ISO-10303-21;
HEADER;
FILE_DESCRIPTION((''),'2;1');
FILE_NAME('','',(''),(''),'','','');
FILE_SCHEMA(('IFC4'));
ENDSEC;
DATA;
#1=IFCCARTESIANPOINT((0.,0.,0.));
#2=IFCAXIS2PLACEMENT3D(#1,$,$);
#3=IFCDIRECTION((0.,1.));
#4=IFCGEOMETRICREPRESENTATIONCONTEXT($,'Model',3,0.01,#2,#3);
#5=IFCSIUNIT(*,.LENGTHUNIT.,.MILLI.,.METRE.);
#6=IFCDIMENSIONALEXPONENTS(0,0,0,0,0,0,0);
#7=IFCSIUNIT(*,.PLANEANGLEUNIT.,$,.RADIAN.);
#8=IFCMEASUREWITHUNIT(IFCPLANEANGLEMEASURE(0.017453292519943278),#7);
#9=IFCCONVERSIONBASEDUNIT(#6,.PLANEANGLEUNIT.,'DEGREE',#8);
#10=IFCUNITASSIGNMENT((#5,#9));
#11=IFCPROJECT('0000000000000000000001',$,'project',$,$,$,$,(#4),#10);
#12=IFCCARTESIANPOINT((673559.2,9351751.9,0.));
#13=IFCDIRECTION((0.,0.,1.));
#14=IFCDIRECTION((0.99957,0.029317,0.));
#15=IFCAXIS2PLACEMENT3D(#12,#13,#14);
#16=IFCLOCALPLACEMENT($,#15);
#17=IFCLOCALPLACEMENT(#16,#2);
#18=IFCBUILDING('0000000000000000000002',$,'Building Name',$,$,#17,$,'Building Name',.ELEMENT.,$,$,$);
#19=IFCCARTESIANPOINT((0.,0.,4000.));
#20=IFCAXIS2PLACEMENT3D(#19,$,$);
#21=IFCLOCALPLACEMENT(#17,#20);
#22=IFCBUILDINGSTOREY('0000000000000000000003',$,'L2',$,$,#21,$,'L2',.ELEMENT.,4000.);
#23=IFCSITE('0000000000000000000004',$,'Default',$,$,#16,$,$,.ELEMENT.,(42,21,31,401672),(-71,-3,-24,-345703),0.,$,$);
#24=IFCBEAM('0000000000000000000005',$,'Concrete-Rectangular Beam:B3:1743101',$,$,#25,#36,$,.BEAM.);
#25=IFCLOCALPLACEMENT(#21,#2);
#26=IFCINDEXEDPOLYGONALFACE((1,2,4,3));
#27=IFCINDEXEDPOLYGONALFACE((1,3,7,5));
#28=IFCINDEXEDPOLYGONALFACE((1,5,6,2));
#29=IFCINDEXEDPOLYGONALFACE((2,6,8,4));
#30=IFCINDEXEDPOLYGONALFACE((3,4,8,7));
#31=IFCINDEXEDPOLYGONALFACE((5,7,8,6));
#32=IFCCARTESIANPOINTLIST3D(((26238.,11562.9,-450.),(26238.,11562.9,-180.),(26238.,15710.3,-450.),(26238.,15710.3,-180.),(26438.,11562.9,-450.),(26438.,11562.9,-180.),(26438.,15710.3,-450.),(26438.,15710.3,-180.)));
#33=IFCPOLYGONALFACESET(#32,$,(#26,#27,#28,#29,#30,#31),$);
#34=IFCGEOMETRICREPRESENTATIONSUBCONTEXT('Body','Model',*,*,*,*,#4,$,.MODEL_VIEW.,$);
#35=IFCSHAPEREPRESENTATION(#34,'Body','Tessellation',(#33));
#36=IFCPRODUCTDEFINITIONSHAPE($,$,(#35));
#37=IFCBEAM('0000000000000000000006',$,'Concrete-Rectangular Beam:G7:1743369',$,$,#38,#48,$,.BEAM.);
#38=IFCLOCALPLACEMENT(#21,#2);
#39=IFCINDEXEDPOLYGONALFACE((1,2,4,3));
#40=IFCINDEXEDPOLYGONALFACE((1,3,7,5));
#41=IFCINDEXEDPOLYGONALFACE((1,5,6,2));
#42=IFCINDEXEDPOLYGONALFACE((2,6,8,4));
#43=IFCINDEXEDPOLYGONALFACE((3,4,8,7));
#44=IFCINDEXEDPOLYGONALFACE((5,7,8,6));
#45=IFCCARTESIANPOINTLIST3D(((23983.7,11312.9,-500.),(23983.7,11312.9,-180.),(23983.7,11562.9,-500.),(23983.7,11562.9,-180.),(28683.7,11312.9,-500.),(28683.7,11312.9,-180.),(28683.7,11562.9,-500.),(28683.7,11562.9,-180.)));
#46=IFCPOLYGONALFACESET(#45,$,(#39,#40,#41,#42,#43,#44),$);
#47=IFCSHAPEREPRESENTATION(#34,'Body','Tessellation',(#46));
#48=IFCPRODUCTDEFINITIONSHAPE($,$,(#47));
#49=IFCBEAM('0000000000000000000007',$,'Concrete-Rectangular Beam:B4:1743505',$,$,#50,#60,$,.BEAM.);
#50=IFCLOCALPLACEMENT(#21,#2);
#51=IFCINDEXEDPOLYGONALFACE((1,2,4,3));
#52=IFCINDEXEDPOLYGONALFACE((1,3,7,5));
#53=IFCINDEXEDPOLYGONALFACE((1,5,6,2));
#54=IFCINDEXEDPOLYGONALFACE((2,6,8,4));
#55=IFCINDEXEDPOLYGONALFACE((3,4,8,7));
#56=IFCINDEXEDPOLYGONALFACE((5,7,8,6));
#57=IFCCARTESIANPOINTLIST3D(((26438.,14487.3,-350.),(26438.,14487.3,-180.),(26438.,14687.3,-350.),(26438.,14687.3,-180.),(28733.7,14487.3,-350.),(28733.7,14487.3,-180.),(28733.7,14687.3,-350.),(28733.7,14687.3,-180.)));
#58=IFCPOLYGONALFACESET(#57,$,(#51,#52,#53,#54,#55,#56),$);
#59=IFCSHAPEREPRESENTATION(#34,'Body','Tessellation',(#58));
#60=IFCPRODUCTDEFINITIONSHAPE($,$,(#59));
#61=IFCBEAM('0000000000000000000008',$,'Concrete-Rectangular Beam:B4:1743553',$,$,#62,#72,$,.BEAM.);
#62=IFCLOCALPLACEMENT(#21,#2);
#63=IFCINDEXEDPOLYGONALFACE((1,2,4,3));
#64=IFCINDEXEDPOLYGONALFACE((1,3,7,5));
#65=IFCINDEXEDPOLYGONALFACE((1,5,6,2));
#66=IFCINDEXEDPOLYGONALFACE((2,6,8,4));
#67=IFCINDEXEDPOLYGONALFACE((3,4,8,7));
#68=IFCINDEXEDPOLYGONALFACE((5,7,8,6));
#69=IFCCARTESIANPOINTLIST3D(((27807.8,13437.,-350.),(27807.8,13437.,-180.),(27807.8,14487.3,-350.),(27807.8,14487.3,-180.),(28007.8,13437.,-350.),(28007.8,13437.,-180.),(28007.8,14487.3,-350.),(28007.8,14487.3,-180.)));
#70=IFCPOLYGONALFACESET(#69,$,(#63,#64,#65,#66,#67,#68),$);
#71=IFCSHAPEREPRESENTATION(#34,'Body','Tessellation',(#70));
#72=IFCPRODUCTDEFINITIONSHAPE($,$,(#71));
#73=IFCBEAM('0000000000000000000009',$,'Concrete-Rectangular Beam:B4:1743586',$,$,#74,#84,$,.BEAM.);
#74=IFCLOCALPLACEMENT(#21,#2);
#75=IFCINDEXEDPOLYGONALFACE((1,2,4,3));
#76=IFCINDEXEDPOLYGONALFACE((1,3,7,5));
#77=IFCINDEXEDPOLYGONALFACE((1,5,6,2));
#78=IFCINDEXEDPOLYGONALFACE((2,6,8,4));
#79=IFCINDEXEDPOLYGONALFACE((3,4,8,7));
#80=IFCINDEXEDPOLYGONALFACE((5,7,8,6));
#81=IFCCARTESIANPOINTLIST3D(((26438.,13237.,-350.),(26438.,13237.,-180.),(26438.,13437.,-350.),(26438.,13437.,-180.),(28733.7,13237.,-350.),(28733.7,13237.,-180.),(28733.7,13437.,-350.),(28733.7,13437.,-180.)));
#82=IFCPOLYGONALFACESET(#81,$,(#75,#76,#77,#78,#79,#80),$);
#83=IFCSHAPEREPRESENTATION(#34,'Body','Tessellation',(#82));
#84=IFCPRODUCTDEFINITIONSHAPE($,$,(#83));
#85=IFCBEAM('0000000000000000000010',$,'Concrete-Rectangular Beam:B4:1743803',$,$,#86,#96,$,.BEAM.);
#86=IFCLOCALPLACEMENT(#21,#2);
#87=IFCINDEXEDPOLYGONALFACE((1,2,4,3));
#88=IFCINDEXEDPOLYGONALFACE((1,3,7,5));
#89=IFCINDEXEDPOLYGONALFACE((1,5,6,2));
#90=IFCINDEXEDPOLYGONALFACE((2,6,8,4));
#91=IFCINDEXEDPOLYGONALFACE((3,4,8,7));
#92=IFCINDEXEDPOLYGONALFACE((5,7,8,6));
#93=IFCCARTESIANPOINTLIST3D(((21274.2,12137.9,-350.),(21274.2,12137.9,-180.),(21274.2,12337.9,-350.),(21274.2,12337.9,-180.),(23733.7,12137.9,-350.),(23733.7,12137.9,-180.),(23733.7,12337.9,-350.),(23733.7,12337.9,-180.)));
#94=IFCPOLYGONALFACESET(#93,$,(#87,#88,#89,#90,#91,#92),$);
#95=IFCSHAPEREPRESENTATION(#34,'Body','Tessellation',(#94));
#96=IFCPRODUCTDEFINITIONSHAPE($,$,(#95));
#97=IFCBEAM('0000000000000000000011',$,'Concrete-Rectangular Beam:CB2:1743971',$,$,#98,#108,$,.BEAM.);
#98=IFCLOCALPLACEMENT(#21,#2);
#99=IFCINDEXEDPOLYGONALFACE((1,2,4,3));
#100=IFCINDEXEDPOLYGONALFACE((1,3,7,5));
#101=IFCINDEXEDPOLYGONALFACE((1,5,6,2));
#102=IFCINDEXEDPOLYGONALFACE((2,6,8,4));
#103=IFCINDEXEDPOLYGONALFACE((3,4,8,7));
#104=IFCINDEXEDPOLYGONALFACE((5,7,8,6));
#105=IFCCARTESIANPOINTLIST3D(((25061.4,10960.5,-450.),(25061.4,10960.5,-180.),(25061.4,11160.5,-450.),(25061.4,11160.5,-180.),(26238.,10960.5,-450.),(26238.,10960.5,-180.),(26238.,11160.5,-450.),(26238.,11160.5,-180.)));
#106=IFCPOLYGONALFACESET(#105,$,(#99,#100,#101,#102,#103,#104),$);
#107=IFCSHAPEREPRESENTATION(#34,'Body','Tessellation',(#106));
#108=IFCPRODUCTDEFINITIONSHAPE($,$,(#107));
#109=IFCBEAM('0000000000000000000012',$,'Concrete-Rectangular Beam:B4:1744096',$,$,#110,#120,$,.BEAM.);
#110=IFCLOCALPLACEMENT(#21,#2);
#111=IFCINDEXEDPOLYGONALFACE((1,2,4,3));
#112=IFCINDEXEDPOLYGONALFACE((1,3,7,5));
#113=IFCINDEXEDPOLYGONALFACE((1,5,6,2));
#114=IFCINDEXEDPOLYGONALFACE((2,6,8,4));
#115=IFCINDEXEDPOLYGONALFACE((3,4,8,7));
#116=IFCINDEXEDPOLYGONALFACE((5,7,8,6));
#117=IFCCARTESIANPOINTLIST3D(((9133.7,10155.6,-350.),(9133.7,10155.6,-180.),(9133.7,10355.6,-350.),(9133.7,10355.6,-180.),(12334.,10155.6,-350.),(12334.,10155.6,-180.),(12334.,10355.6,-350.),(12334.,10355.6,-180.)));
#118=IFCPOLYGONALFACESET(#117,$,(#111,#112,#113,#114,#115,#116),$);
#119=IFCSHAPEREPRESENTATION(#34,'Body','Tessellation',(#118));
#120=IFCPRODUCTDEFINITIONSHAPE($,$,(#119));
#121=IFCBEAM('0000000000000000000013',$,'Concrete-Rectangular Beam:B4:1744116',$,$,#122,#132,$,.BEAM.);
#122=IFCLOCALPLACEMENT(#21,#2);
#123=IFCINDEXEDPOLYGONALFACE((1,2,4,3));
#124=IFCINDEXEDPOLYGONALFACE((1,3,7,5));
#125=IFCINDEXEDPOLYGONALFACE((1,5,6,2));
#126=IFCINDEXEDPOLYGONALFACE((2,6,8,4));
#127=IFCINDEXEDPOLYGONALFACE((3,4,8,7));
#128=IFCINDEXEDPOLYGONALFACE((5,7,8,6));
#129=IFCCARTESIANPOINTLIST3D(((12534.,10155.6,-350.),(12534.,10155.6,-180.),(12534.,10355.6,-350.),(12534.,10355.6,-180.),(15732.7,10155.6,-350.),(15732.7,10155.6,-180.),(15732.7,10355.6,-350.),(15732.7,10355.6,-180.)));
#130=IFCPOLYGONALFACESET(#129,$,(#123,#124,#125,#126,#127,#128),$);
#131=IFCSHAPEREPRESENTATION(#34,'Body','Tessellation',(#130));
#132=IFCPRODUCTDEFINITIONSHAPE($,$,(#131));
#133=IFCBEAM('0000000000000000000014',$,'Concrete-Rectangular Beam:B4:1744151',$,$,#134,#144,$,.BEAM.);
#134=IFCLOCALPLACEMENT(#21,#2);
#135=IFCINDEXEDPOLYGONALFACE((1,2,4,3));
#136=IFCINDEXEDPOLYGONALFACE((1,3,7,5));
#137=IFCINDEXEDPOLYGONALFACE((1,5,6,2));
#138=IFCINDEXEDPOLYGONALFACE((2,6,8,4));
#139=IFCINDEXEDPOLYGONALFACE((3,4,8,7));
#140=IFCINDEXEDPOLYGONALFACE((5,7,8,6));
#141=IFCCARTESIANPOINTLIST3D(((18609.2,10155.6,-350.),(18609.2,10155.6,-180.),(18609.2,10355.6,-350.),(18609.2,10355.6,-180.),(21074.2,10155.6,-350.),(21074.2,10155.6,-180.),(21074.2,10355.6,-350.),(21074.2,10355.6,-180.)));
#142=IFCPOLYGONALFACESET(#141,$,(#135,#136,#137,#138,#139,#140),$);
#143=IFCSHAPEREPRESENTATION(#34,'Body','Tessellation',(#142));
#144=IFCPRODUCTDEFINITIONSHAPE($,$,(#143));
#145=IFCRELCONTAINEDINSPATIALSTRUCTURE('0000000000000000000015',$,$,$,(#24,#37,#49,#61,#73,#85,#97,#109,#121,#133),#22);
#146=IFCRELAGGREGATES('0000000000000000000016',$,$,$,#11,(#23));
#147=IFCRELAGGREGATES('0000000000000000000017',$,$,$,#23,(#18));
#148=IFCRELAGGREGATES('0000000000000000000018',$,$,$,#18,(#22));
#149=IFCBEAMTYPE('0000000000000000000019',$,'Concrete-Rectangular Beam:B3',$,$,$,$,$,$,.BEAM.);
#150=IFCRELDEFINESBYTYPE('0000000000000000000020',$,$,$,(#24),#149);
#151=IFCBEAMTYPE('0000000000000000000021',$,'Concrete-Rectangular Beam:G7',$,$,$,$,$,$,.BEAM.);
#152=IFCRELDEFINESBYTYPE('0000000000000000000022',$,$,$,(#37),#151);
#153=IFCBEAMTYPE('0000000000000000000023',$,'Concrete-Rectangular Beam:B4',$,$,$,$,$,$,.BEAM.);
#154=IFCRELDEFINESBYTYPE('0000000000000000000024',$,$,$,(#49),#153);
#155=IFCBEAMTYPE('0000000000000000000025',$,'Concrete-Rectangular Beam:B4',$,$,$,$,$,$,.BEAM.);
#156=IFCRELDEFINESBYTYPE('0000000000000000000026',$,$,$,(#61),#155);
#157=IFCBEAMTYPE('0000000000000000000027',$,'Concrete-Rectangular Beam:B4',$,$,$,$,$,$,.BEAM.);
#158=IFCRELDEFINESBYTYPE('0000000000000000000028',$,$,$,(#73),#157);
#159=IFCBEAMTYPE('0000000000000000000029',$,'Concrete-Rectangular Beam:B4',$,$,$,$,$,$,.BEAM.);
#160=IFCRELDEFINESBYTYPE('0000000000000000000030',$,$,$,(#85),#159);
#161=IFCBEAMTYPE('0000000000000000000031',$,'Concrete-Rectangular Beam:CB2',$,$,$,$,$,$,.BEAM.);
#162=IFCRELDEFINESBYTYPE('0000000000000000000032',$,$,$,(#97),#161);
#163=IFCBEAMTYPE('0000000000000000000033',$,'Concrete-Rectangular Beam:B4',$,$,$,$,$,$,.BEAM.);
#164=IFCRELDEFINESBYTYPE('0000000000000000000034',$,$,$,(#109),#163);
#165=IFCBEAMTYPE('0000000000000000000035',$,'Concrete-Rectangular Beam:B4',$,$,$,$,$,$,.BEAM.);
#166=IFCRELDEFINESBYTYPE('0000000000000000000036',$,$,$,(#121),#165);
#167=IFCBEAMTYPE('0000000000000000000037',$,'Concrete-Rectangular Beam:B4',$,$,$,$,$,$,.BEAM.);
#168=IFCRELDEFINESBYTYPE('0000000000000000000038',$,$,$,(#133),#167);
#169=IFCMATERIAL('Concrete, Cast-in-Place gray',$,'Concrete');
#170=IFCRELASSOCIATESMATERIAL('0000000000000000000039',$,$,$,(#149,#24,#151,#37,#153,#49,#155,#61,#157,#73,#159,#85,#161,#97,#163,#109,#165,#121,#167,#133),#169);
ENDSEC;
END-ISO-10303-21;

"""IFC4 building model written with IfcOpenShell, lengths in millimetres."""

from ifc_helpers import new_model, entity, si_unit, converted_unit, direction, frame, origin, place, context, subcontext, project, spatial, indexed_curve, outline, extrude, source, transform, mapped, material, type_object, type_shapes, element, save


model = new_model("IFC4")

# Units and contexts
model_context = context("Model", 3, precision=0.01, world=origin(), true_north=direction((0.0, 1.0)))
body_context = subcontext(model_context, "Body", "Model", "MODEL_VIEW")
ifc_project = project(units=[si_unit("LENGTHUNIT", "METRE", prefix="MILLI"), converted_unit("PLANEANGLEUNIT", "DEGREE", entity("IfcPlaneAngleMeasure", 0.017453292519943278), si_unit("PLANEANGLEUNIT", "RADIAN"), dimensions=[0, 0, 0, 0, 0, 0, 0])], contexts=[model_context])

# Site, building, storey
site_placement = place(None, frame((673559.2, 9351751.9, 0.0), z_axis=(0.0, 0.0, 1.0), x_axis=(0.99957, 0.029317, 0.0)))
site = spatial("IfcSite", under=ifc_project, at=site_placement, Name="Default", CompositionType="ELEMENT", RefLatitude=(42, 21, 31, 401672), RefLongitude=(-71, -3, -24, -345703), RefElevation=0.0)
building_placement = place(site_placement, origin())
building = spatial("IfcBuilding", under=site, at=building_placement, Name="Building Name", LongName="Building Name", CompositionType="ELEMENT")
storey_placement = place(building_placement, frame((0.0, 0.0, 4000.0)))
storey = spatial("IfcBuildingStorey", under=building, at=storey_placement, Name="L2", LongName="L2", CompositionType="ELEMENT", Elevation=4000.0)

# Shared definitions
ifc_material = material(Name="Concrete, Cast-in-Place gray", Category="Concrete")

# Beams
beam_type_1 = type_object("IfcBeamType", Name="Concrete-Rectangular Beam:B3", PredefinedType="BEAM", material=ifc_material)
shared_shape_1 = source(origin(), body_context, "Body", "SweptSolid", [
    extrude(outline(indexed_curve([(-100.0, -135.0), (100.0, -135.0), (100.0, 135.0), (-100.0, 135.0), (-100.0, -135.0)], self_intersect=False)), frame((26338.0, 15710.3, 3685.0), z_axis=(0.0, -1.0, 0.0), x_axis=(-1.0, 0.0, 0.0)), (0.0, 0.0, 1.0), 4147.4),
])
type_shapes(beam_type_1, [shared_shape_1])
beam_1_placement = place(storey_placement, frame((0.0, 0.0, -4000.0)))
element("IfcBeam", 1, at=beam_1_placement, inside=storey, type_object=beam_type_1, material=ifc_material, Name="Concrete-Rectangular Beam:B3:1743101", PredefinedType="BEAM", context=body_context, shape_type="MappedRepresentation", body=[
    mapped(shared_shape_1, transform((0.0, 0.0, 0.0), scale=1.0)),
])
beam_type_2 = type_object("IfcBeamType", Name="Concrete-Rectangular Beam:G7", PredefinedType="BEAM", material=ifc_material)
shared_shape_2 = source(origin(), body_context, "Body", "SweptSolid", [
    extrude(outline(indexed_curve([(-160.0, -125.0), (160.0, -125.0), (160.0, 125.0), (-160.0, 125.0), (-160.0, -125.0)], self_intersect=False)), frame((23983.7, 11437.9, 3660.0), z_axis=(1.0, 0.0, 0.0), x_axis=(0.0, 0.0, -1.0)), (0.0, 0.0, 1.0), 4700.0),
])
type_shapes(beam_type_2, [shared_shape_2])
beam_2_placement = place(storey_placement, frame((0.0, 0.0, -4000.0)))
element("IfcBeam", 2, at=beam_2_placement, inside=storey, type_object=beam_type_2, material=ifc_material, Name="Concrete-Rectangular Beam:G7:1743369", PredefinedType="BEAM", context=body_context, shape_type="MappedRepresentation", body=[
    mapped(shared_shape_2, transform((0.0, 0.0, 0.0), scale=1.0)),
])
beam_type_3 = type_object("IfcBeamType", Name="Concrete-Rectangular Beam:B4", PredefinedType="BEAM", material=ifc_material)
shared_shape_3 = source(origin(), body_context, "Body", "SweptSolid", [
    extrude(outline(indexed_curve([(-85.0, -100.0), (85.0, -100.0), (85.0, 100.0), (-85.0, 100.0), (-85.0, -100.0)], self_intersect=False)), frame((28733.7, 14587.3, 3735.0), z_axis=(-1.0, 0.0, 0.0), x_axis=(0.0, 0.0, -1.0)), (0.0, 0.0, 1.0), 2295.7),
])
type_shapes(beam_type_3, [shared_shape_3])
beam_3_placement = place(storey_placement, frame((0.0, 0.0, -4000.0)))
element("IfcBeam", 3, at=beam_3_placement, inside=storey, type_object=beam_type_3, material=ifc_material, Name="Concrete-Rectangular Beam:B4:1743505", PredefinedType="BEAM", context=body_context, shape_type="MappedRepresentation", body=[
    mapped(shared_shape_3, transform((0.0, 0.0, 0.0), scale=1.0)),
])
beam_type_4 = type_object("IfcBeamType", Name="Concrete-Rectangular Beam:B4", PredefinedType="BEAM", material=ifc_material)
shared_shape_4 = source(origin(), body_context, "Body", "SweptSolid", [
    extrude(outline(indexed_curve([(-100.0, -85.0), (100.0, -85.0), (100.0, 85.0), (-100.0, 85.0), (-100.0, -85.0)], self_intersect=False)), frame((27907.8, 14487.3, 3735.0), z_axis=(0.0, -1.0, 0.0), x_axis=(-1.0, 0.0, 0.0)), (0.0, 0.0, 1.0), 1050.3),
])
type_shapes(beam_type_4, [shared_shape_4])
beam_4_placement = place(storey_placement, frame((0.0, 0.0, -4000.0)))
element("IfcBeam", 4, at=beam_4_placement, inside=storey, type_object=beam_type_4, material=ifc_material, Name="Concrete-Rectangular Beam:B4:1743553", PredefinedType="BEAM", context=body_context, shape_type="MappedRepresentation", body=[
    mapped(shared_shape_4, transform((0.0, 0.0, 0.0), scale=1.0)),
])
beam_type_5 = type_object("IfcBeamType", Name="Concrete-Rectangular Beam:B4", PredefinedType="BEAM", material=ifc_material)
shared_shape_5 = source(origin(), body_context, "Body", "SweptSolid", [
    extrude(outline(indexed_curve([(-85.0, -100.0), (85.0, -100.0), (85.0, 100.0), (-85.0, 100.0), (-85.0, -100.0)], self_intersect=False)), frame((28733.7, 13337.0, 3735.0), z_axis=(-1.0, 0.0, 0.0), x_axis=(0.0, 0.0, -1.0)), (0.0, 0.0, 1.0), 2295.7),
])
type_shapes(beam_type_5, [shared_shape_5])
beam_5_placement = place(storey_placement, frame((0.0, 0.0, -4000.0)))
element("IfcBeam", 5, at=beam_5_placement, inside=storey, type_object=beam_type_5, material=ifc_material, Name="Concrete-Rectangular Beam:B4:1743586", PredefinedType="BEAM", context=body_context, shape_type="MappedRepresentation", body=[
    mapped(shared_shape_5, transform((0.0, 0.0, 0.0), scale=1.0)),
])
beam_type_6 = type_object("IfcBeamType", Name="Concrete-Rectangular Beam:B4", PredefinedType="BEAM", material=ifc_material)
shared_shape_6 = source(origin(), body_context, "Body", "SweptSolid", [
    extrude(outline(indexed_curve([(-85.0, -100.0), (85.0, -100.0), (85.0, 100.0), (-85.0, 100.0), (-85.0, -100.0)], self_intersect=False)), frame((21274.2, 12237.9, 3735.0), z_axis=(1.0, 0.0, 0.0), x_axis=(0.0, 0.0, -1.0)), (0.0, 0.0, 1.0), 2459.5),
])
type_shapes(beam_type_6, [shared_shape_6])
beam_6_placement = place(storey_placement, frame((0.0, 0.0, -4000.0)))
element("IfcBeam", 6, at=beam_6_placement, inside=storey, type_object=beam_type_6, material=ifc_material, Name="Concrete-Rectangular Beam:B4:1743803", PredefinedType="BEAM", context=body_context, shape_type="MappedRepresentation", body=[
    mapped(shared_shape_6, transform((0.0, 0.0, 0.0), scale=1.0)),
])
beam_type_7 = type_object("IfcBeamType", Name="Concrete-Rectangular Beam:CB2", PredefinedType="BEAM", material=ifc_material)
shared_shape_7 = source(origin(), body_context, "Body", "SweptSolid", [
    extrude(outline(indexed_curve([(-135.0, -100.0), (135.0, -100.0), (135.0, 100.0), (-135.0, 100.0), (-135.0, -100.0)], self_intersect=False)), frame((25061.4, 11060.5, 3685.0), z_axis=(1.0, 0.0, 0.0), x_axis=(0.0, 0.0, -1.0)), (0.0, 0.0, 1.0), 1176.6),
])
type_shapes(beam_type_7, [shared_shape_7])
beam_7_placement = place(storey_placement, frame((0.0, 0.0, -4000.0)))
element("IfcBeam", 7, at=beam_7_placement, inside=storey, type_object=beam_type_7, material=ifc_material, Name="Concrete-Rectangular Beam:CB2:1743971", PredefinedType="BEAM", context=body_context, shape_type="MappedRepresentation", body=[
    mapped(shared_shape_7, transform((0.0, 0.0, 0.0), scale=1.0)),
])
beam_type_8 = type_object("IfcBeamType", Name="Concrete-Rectangular Beam:B4", PredefinedType="BEAM", material=ifc_material)
shared_shape_8 = source(origin(), body_context, "Body", "SweptSolid", [
    extrude(outline(indexed_curve([(-85.0, -100.0), (85.0, -100.0), (85.0, 100.0), (-85.0, 100.0), (-85.0, -100.0)], self_intersect=False)), frame((9133.7, 10255.6, 3735.0), z_axis=(1.0, 0.0, 0.0), x_axis=(0.0, 0.0, -1.0)), (0.0, 0.0, 1.0), 3200.3),
])
type_shapes(beam_type_8, [shared_shape_8])
beam_8_placement = place(storey_placement, frame((0.0, 0.0, -4000.0)))
element("IfcBeam", 8, at=beam_8_placement, inside=storey, type_object=beam_type_8, material=ifc_material, Name="Concrete-Rectangular Beam:B4:1744096", PredefinedType="BEAM", context=body_context, shape_type="MappedRepresentation", body=[
    mapped(shared_shape_8, transform((0.0, 0.0, 0.0), scale=1.0)),
])
beam_type_9 = type_object("IfcBeamType", Name="Concrete-Rectangular Beam:B4", PredefinedType="BEAM", material=ifc_material)
shared_shape_9 = source(origin(), body_context, "Body", "SweptSolid", [
    extrude(outline(indexed_curve([(-85.0, -100.0), (85.0, -100.0), (85.0, 100.0), (-85.0, 100.0), (-85.0, -100.0)], self_intersect=False)), frame((12534.0, 10255.6, 3735.0), z_axis=(1.0, 0.0, 0.0), x_axis=(0.0, 0.0, -1.0)), (0.0, 0.0, 1.0), 3198.6),
])
type_shapes(beam_type_9, [shared_shape_9])
beam_9_placement = place(storey_placement, frame((0.0, 0.0, -4000.0)))
element("IfcBeam", 9, at=beam_9_placement, inside=storey, type_object=beam_type_9, material=ifc_material, Name="Concrete-Rectangular Beam:B4:1744116", PredefinedType="BEAM", context=body_context, shape_type="MappedRepresentation", body=[
    mapped(shared_shape_9, transform((0.0, 0.0, 0.0), scale=1.0)),
])
beam_type_10 = type_object("IfcBeamType", Name="Concrete-Rectangular Beam:B4", PredefinedType="BEAM", material=ifc_material)
shared_shape_10 = source(origin(), body_context, "Body", "SweptSolid", [
    extrude(outline(indexed_curve([(-85.0, -100.0), (85.0, -100.0), (85.0, 100.0), (-85.0, 100.0), (-85.0, -100.0)], self_intersect=False)), frame((18609.2, 10255.6, 3735.0), z_axis=(1.0, 0.0, 0.0), x_axis=(0.0, 0.0, -1.0)), (0.0, 0.0, 1.0), 2465.0),
])
type_shapes(beam_type_10, [shared_shape_10])
beam_10_placement = place(storey_placement, frame((0.0, 0.0, -4000.0)))
element("IfcBeam", 10, at=beam_10_placement, inside=storey, type_object=beam_type_10, material=ifc_material, Name="Concrete-Rectangular Beam:B4:1744151", PredefinedType="BEAM", context=body_context, shape_type="MappedRepresentation", body=[
    mapped(shared_shape_10, transform((0.0, 0.0, 0.0), scale=1.0)),
])

save(model, "model.ifc")
